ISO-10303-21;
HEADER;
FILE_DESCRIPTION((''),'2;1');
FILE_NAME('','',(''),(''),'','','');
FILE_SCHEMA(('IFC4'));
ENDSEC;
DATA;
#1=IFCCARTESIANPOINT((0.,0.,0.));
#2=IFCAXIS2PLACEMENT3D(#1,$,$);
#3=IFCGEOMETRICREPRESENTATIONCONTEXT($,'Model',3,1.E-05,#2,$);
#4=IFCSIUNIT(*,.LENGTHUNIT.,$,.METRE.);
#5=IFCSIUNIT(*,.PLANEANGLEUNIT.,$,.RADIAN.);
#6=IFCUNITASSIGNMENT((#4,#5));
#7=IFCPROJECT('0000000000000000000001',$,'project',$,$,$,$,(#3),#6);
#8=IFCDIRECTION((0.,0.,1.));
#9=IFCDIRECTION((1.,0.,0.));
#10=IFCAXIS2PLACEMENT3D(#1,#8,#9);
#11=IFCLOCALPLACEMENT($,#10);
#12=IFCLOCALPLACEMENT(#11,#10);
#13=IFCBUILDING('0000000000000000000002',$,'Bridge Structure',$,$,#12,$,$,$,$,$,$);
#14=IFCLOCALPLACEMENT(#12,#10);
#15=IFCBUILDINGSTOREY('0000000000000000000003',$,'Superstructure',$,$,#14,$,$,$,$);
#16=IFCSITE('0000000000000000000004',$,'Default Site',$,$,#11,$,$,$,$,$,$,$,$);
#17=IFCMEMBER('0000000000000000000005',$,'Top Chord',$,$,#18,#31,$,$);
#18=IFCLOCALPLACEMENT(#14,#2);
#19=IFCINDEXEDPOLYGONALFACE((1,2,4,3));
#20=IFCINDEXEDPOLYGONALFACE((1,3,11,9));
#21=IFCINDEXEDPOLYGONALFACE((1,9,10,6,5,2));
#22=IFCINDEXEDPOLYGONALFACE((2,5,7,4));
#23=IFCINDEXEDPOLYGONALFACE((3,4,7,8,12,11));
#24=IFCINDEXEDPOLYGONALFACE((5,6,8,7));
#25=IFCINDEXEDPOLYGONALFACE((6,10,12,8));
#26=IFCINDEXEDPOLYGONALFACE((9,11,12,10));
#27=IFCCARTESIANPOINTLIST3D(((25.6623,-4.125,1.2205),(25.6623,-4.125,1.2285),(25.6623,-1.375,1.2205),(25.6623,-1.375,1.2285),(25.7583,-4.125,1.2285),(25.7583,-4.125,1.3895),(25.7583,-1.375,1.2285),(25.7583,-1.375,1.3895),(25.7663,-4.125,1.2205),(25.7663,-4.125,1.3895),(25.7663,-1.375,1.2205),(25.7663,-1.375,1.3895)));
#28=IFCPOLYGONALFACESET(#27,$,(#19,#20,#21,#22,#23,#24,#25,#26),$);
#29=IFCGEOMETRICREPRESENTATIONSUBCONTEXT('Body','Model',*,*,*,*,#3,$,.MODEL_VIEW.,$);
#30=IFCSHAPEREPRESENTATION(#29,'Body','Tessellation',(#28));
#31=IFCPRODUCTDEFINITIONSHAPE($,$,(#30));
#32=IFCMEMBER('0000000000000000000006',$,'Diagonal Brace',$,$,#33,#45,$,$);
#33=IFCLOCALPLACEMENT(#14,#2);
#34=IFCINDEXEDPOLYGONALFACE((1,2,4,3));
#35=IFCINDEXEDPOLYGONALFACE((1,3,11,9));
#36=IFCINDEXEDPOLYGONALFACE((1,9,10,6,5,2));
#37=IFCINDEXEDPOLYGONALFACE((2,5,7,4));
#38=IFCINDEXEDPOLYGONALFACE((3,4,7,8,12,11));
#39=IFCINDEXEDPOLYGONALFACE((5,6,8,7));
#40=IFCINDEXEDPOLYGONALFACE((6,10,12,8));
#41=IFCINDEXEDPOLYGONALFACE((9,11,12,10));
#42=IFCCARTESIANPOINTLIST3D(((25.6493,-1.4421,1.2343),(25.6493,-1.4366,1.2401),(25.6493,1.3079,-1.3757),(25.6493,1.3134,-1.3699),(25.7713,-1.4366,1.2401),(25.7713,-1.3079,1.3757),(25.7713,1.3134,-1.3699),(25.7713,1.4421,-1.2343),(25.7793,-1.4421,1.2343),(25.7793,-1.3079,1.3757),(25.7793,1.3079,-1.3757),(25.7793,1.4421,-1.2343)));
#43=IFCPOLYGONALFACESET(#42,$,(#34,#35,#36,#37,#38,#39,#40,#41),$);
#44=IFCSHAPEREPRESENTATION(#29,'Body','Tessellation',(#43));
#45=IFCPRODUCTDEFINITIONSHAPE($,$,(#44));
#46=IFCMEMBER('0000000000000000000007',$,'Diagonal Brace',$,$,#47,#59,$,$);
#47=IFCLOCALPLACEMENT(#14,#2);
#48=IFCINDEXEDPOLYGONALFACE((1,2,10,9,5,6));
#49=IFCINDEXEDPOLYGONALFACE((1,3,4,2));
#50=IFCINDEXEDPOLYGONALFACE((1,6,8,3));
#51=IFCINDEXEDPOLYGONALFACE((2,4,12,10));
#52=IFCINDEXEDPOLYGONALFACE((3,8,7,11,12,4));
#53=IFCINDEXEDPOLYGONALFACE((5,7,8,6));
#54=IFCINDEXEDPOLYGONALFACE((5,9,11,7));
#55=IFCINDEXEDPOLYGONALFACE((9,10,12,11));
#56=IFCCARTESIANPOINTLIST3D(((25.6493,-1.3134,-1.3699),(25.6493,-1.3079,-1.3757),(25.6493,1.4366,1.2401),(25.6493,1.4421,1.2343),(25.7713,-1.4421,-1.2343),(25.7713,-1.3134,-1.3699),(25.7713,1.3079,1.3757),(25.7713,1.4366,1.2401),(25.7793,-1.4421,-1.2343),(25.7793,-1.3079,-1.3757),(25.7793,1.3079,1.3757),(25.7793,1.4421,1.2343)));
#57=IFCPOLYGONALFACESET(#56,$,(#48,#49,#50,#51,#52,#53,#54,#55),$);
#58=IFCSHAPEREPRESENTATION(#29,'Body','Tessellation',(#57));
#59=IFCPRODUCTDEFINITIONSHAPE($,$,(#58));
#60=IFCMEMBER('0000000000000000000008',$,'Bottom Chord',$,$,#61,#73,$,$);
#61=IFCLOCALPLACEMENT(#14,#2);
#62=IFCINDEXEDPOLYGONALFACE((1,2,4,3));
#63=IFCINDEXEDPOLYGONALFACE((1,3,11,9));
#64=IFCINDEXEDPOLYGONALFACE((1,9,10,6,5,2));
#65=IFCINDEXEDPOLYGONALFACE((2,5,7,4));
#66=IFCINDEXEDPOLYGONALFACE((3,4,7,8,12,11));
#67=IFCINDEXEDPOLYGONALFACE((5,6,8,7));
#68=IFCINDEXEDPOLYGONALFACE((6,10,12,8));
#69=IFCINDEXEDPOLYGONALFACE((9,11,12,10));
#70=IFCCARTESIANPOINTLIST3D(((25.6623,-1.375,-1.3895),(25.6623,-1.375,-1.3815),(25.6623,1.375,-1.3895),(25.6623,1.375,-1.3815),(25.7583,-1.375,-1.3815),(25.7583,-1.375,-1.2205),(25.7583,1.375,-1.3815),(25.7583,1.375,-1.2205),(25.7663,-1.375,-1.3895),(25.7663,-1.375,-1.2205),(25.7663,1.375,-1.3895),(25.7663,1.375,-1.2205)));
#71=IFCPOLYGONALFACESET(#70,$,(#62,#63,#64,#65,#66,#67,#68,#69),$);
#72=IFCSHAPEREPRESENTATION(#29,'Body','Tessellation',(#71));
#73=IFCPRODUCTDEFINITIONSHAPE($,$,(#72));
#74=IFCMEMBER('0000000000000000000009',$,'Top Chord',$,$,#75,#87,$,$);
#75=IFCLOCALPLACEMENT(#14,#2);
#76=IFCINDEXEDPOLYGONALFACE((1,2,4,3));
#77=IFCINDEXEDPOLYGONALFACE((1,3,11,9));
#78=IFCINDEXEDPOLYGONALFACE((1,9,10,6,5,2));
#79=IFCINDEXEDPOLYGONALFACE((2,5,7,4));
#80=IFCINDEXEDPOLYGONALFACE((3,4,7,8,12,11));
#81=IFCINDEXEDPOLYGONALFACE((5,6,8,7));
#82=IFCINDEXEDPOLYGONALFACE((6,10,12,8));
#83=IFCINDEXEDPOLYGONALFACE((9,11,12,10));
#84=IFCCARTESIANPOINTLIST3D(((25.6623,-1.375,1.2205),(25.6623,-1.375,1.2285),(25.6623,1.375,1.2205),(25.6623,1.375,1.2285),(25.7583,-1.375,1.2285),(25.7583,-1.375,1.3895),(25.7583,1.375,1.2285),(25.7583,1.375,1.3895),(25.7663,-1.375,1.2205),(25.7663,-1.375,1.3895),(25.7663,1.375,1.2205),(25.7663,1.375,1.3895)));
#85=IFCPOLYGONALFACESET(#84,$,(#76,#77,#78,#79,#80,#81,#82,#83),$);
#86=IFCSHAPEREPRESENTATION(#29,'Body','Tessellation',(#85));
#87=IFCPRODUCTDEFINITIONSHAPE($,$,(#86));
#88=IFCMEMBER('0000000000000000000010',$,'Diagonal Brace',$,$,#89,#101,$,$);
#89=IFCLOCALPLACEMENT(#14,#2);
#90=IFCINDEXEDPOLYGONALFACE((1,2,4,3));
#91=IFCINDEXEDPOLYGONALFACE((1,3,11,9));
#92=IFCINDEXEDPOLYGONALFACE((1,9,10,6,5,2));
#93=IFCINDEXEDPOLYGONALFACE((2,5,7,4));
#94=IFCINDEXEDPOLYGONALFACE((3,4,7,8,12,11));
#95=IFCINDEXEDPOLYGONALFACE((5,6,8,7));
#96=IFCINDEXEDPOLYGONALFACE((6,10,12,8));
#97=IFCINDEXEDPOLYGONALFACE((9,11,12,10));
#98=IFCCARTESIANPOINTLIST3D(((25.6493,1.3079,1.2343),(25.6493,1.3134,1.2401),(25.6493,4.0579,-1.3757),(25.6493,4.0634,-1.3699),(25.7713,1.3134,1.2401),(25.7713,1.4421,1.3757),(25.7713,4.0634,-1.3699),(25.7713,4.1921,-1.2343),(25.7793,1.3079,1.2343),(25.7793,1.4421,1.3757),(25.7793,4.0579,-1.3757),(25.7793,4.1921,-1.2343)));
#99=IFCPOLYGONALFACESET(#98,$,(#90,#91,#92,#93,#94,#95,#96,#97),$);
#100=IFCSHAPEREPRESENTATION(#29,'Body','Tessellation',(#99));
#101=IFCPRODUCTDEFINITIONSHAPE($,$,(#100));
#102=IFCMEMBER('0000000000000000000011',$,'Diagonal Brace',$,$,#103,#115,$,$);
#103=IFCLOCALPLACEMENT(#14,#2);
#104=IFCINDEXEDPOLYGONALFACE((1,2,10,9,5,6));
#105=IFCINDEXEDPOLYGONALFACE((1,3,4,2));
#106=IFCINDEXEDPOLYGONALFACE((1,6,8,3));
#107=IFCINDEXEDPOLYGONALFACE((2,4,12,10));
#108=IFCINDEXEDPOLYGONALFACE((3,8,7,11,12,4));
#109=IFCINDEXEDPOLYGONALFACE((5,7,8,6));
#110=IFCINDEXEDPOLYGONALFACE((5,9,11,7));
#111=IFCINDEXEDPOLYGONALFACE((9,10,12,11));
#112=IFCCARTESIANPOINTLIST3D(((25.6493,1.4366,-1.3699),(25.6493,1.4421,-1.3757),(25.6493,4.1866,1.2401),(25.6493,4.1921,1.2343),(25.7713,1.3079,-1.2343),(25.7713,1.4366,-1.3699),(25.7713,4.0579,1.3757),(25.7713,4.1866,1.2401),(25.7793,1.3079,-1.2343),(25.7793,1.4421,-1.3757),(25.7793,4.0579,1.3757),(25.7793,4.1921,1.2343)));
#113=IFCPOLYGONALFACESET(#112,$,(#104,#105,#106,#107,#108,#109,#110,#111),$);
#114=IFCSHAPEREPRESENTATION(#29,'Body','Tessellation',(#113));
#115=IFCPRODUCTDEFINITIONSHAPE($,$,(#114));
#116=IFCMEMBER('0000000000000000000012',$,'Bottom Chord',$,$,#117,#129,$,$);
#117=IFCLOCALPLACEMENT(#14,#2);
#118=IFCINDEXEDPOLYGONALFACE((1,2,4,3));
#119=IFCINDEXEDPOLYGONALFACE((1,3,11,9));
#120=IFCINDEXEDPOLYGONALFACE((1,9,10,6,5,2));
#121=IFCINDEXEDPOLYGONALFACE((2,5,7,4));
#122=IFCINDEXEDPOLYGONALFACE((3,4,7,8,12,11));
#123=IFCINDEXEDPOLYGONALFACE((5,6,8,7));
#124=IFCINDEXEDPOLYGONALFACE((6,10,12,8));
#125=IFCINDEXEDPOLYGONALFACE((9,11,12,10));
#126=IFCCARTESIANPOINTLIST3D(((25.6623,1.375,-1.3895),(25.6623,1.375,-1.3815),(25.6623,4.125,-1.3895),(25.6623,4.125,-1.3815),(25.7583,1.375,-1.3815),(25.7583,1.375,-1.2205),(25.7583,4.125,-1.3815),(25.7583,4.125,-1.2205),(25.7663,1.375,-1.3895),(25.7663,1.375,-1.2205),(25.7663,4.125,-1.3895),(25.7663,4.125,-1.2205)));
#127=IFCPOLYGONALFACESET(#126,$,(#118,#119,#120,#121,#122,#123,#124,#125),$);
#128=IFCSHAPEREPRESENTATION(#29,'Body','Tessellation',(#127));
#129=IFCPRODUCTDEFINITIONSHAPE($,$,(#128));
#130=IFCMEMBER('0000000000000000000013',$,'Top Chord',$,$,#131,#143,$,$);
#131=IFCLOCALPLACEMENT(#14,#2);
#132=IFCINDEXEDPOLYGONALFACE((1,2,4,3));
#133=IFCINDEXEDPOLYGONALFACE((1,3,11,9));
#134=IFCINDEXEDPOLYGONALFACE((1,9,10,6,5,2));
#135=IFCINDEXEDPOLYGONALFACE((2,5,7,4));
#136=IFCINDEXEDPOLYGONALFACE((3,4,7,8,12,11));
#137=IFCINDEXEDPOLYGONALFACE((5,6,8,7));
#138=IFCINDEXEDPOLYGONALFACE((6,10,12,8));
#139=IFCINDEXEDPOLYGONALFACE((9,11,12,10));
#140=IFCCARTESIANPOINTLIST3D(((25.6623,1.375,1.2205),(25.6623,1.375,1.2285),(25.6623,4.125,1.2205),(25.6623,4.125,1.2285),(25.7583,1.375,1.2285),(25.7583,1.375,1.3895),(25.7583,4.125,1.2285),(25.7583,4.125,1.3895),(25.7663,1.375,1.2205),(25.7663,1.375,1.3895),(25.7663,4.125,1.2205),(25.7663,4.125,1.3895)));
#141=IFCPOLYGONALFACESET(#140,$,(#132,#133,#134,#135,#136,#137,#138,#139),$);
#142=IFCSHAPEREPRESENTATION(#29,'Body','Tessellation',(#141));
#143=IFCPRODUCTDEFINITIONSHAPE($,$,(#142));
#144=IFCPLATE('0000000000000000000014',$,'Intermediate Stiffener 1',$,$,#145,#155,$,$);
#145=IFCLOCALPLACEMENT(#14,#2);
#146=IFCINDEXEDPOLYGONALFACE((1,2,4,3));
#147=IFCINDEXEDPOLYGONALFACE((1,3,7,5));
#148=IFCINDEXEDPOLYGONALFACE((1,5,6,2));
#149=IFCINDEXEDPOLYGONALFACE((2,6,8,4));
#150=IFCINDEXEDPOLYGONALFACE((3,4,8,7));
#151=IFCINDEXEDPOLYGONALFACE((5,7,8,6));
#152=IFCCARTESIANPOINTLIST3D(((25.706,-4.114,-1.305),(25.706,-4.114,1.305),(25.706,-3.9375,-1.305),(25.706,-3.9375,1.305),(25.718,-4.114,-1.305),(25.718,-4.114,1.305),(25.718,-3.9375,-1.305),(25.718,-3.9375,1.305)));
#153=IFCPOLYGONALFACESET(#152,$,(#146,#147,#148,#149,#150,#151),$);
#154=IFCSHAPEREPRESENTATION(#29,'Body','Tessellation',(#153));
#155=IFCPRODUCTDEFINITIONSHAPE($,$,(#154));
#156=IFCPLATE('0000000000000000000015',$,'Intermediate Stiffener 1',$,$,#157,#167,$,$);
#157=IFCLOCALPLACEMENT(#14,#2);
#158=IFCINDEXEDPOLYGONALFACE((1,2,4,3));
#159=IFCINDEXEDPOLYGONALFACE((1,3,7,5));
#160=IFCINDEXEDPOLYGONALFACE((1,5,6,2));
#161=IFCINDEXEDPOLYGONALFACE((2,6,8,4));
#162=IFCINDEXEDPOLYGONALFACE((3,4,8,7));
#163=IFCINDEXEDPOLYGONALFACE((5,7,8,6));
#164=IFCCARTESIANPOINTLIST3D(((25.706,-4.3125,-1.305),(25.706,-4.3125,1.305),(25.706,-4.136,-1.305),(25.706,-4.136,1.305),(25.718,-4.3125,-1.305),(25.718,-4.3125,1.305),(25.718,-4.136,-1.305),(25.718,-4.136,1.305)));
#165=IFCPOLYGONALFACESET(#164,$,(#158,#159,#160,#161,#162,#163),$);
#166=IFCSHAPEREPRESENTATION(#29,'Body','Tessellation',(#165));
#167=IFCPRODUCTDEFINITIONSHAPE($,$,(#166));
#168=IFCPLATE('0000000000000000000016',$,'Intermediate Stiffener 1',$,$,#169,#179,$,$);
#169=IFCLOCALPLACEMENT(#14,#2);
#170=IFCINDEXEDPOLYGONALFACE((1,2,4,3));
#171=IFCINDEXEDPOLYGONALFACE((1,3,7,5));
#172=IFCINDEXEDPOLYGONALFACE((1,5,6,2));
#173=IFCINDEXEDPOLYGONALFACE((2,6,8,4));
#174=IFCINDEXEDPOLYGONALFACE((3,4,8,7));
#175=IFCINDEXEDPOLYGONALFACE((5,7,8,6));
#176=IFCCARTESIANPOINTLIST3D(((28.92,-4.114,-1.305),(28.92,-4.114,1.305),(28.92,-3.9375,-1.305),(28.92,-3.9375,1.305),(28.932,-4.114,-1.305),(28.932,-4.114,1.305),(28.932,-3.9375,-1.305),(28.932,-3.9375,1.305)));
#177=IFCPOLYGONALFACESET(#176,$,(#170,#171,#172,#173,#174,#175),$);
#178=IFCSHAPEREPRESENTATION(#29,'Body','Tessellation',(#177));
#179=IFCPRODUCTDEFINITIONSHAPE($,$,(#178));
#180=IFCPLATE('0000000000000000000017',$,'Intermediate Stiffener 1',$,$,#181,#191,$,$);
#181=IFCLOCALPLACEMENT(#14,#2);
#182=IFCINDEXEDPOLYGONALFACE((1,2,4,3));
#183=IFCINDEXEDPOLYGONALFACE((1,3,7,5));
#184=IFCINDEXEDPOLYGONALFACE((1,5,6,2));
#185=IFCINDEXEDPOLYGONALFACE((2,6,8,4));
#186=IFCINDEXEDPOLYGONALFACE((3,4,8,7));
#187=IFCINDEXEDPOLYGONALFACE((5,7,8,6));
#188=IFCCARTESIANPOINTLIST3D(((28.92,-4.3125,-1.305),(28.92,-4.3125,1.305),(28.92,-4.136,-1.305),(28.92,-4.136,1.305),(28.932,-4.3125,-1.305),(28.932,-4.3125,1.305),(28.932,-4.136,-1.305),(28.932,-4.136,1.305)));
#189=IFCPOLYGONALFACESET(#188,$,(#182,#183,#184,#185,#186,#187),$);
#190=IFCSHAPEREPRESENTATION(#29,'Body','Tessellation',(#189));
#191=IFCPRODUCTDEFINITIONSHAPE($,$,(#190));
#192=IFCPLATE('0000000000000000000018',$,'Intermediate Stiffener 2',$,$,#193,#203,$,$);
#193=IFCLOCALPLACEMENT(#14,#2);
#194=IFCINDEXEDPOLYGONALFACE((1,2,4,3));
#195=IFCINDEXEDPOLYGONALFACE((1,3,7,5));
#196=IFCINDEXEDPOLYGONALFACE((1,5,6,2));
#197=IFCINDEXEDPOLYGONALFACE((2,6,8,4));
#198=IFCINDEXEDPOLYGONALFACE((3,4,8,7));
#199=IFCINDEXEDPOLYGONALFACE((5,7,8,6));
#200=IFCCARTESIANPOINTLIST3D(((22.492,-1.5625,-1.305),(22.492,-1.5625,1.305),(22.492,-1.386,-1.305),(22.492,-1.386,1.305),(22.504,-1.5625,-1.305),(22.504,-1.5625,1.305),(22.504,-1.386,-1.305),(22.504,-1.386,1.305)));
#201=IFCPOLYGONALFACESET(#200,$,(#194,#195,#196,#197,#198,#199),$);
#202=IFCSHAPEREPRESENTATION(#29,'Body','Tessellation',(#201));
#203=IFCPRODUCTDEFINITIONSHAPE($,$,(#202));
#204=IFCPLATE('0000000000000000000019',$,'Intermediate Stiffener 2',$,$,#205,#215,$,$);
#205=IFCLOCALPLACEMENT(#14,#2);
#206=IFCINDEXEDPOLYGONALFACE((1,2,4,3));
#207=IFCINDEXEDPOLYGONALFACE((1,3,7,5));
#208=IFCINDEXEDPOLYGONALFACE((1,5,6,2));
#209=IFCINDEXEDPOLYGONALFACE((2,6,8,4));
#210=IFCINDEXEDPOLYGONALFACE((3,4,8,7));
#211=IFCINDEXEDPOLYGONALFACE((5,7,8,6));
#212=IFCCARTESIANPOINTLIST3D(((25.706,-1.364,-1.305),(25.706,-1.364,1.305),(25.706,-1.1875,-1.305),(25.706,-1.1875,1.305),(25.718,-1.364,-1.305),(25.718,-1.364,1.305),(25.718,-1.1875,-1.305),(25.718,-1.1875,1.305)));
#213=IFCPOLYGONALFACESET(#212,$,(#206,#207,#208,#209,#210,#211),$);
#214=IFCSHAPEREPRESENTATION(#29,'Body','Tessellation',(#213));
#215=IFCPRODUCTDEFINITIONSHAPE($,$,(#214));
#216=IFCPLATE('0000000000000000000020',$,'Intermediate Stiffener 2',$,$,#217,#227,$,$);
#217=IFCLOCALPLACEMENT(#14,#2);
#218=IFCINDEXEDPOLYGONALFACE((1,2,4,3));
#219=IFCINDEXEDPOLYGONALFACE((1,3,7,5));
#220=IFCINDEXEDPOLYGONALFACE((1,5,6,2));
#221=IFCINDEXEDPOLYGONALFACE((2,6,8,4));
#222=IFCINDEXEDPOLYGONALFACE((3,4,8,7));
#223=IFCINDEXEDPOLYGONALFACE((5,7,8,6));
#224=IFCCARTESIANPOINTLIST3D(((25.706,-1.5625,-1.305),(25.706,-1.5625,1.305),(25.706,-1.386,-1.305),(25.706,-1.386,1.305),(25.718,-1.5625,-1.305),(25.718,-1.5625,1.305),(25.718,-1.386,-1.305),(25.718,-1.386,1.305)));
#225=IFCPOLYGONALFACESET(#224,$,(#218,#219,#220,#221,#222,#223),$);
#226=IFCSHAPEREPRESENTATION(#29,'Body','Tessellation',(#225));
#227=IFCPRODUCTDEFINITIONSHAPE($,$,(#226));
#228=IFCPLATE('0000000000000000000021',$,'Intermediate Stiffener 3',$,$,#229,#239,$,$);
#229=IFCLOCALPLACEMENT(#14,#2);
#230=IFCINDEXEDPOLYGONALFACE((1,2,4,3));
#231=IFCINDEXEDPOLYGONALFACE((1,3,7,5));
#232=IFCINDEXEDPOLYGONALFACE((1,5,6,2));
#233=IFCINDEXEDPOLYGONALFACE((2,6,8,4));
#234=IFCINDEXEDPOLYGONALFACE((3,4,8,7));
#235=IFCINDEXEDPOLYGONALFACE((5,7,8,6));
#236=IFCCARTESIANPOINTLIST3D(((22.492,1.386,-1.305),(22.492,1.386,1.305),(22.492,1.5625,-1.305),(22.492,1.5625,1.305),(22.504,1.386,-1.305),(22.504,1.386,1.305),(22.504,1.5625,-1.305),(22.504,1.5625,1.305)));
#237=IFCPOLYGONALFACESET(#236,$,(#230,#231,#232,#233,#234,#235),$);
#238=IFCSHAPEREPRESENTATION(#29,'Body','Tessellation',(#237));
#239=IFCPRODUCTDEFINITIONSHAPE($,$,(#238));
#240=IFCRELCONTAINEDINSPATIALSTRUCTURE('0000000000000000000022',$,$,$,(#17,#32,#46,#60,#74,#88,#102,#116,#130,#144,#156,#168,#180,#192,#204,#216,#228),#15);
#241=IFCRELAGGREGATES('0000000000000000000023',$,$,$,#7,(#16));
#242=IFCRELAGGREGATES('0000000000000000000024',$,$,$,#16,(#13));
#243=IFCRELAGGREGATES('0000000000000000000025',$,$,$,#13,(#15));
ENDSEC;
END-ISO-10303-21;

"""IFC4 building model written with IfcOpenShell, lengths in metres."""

from ifc_helpers import new_model, si_unit, frame, origin, origin_with_axes, origin_2d_with_axis, place, context, subcontext, project, spatial, rectangle, l_section, extrude, element, save


model = new_model("IFC4")

# Units and contexts
model_context = context("Model", 3, precision=1e-05, world=origin())
body_context = subcontext(model_context, "Body", "Model", "MODEL_VIEW")
ifc_project = project(units=[si_unit("LENGTHUNIT", "METRE"), si_unit("PLANEANGLEUNIT", "RADIAN")], contexts=[model_context])

# Site, building, storey
site_placement = place(None, origin_with_axes())
site = spatial("IfcSite", under=ifc_project, at=site_placement, Name="Default Site")
building_placement = place(site_placement, origin_with_axes())
building = spatial("IfcBuilding", under=site, at=building_placement, Name="Bridge Structure")
storey_placement = place(building_placement, origin_with_axes())
storey = spatial("IfcBuildingStorey", under=building, at=storey_placement, Name="Superstructure")

# Members
for number, where, z_axis, x_axis, name in (
    (1, (25.7143, -4.125, 1.305), (0.0, 1.0, 0.0), (-1.0, 0.0, 0.0), "Top Chord"),
):
    element("IfcMember", number, at=place(storey_placement, frame(where, z_axis=z_axis, x_axis=x_axis)), inside=storey, Name=name, context=body_context, shape_type="SweptSolid", body=[
        extrude(l_section(Depth=0.169, Width=0.104, Thickness=0.008, at=origin_2d_with_axis()), origin_with_axes(), (0.0, 0.0, 1.0), 2.75),
    ])
for number, where, z_axis, x_axis, name in (
    (2, (25.7143, -1.375, 1.305), (0.0, 0.725329, -0.688403), (-1.0, 0.0, 0.0), "Diagonal Brace"),
    (3, (25.7143, -1.375, -1.305), (0.0, 0.725329, 0.688403), (-1.0, 0.0, 0.0), "Diagonal Brace"),
):
    element("IfcMember", number, at=place(storey_placement, frame(where, z_axis=z_axis, x_axis=x_axis)), inside=storey, Name=name, context=body_context, shape_type="SweptSolid", body=[
        extrude(l_section(Depth=0.195, Width=0.13, Thickness=0.008, at=origin_2d_with_axis()), origin_with_axes(), (0.0, 0.0, 1.0), 3.7914),
    ])
for number, where, z_axis, x_axis, name in (
    (4, (25.7143, -1.375, -1.305), (0.0, 1.0, 0.0), (-1.0, 0.0, 0.0), "Bottom Chord"),
    (5, (25.7143, -1.375, 1.305), (0.0, 1.0, 0.0), (-1.0, 0.0, 0.0), "Top Chord"),
):
    element("IfcMember", number, at=place(storey_placement, frame(where, z_axis=z_axis, x_axis=x_axis)), inside=storey, Name=name, context=body_context, shape_type="SweptSolid", body=[
        extrude(l_section(Depth=0.169, Width=0.104, Thickness=0.008, at=origin_2d_with_axis()), origin_with_axes(), (0.0, 0.0, 1.0), 2.75),
    ])
for number, where, z_axis, x_axis, name in (
    (6, (25.7143, 1.375, 1.305), (0.0, 0.725329, -0.688403), (-1.0, 0.0, 0.0), "Diagonal Brace"),
    (7, (25.7143, 1.375, -1.305), (0.0, 0.725329, 0.688403), (-1.0, 0.0, 0.0), "Diagonal Brace"),
):
    element("IfcMember", number, at=place(storey_placement, frame(where, z_axis=z_axis, x_axis=x_axis)), inside=storey, Name=name, context=body_context, shape_type="SweptSolid", body=[
        extrude(l_section(Depth=0.195, Width=0.13, Thickness=0.008, at=origin_2d_with_axis()), origin_with_axes(), (0.0, 0.0, 1.0), 3.7914),
    ])
for number, where, z_axis, x_axis, name in (
    (8, (25.7143, 1.375, -1.305), (0.0, 1.0, 0.0), (-1.0, 0.0, 0.0), "Bottom Chord"),
    (9, (25.7143, 1.375, 1.305), (0.0, 1.0, 0.0), (-1.0, 0.0, 0.0), "Top Chord"),
):
    element("IfcMember", number, at=place(storey_placement, frame(where, z_axis=z_axis, x_axis=x_axis)), inside=storey, Name=name, context=body_context, shape_type="SweptSolid", body=[
        extrude(l_section(Depth=0.169, Width=0.104, Thickness=0.008, at=origin_2d_with_axis()), origin_with_axes(), (0.0, 0.0, 1.0), 2.75),
    ])

# Plates
for number, where, z_axis, x_axis, name in (
    (10, (25.712, -4.0258, -1.305), (0.0, 0.0, 1.0), (1.0, 0.0, 0.0), "Intermediate Stiffener 1"),
    (11, (25.712, -4.2243, -1.305), (0.0, 0.0, 1.0), (1.0, 0.0, 0.0), "Intermediate Stiffener 1"),
    (12, (28.926, -4.0258, -1.305), (0.0, 0.0, 1.0), (1.0, 0.0, 0.0), "Intermediate Stiffener 1"),
    (13, (28.926, -4.2243, -1.305), (0.0, 0.0, 1.0), (1.0, 0.0, 0.0), "Intermediate Stiffener 1"),
    (14, (22.498, -1.4743, -1.305), (0.0, 0.0, 1.0), (1.0, 0.0, 0.0), "Intermediate Stiffener 2"),
    (15, (25.712, -1.2757, -1.305), (0.0, 0.0, 1.0), (1.0, 0.0, 0.0), "Intermediate Stiffener 2"),
    (16, (25.712, -1.4743, -1.305), (0.0, 0.0, 1.0), (1.0, 0.0, 0.0), "Intermediate Stiffener 2"),
    (17, (22.498, 1.4743, -1.305), (0.0, 0.0, 1.0), (1.0, 0.0, 0.0), "Intermediate Stiffener 3"),
):
    element("IfcPlate", number, at=place(storey_placement, frame(where, z_axis=z_axis, x_axis=x_axis)), inside=storey, Name=name, context=body_context, shape_type="SweptSolid", body=[
        extrude(rectangle(XDim=0.012, YDim=0.1765, at=origin_2d_with_axis()), origin_with_axes(), (0.0, 0.0, 1.0), 2.61),
    ])

save(model, "model.ifc")
